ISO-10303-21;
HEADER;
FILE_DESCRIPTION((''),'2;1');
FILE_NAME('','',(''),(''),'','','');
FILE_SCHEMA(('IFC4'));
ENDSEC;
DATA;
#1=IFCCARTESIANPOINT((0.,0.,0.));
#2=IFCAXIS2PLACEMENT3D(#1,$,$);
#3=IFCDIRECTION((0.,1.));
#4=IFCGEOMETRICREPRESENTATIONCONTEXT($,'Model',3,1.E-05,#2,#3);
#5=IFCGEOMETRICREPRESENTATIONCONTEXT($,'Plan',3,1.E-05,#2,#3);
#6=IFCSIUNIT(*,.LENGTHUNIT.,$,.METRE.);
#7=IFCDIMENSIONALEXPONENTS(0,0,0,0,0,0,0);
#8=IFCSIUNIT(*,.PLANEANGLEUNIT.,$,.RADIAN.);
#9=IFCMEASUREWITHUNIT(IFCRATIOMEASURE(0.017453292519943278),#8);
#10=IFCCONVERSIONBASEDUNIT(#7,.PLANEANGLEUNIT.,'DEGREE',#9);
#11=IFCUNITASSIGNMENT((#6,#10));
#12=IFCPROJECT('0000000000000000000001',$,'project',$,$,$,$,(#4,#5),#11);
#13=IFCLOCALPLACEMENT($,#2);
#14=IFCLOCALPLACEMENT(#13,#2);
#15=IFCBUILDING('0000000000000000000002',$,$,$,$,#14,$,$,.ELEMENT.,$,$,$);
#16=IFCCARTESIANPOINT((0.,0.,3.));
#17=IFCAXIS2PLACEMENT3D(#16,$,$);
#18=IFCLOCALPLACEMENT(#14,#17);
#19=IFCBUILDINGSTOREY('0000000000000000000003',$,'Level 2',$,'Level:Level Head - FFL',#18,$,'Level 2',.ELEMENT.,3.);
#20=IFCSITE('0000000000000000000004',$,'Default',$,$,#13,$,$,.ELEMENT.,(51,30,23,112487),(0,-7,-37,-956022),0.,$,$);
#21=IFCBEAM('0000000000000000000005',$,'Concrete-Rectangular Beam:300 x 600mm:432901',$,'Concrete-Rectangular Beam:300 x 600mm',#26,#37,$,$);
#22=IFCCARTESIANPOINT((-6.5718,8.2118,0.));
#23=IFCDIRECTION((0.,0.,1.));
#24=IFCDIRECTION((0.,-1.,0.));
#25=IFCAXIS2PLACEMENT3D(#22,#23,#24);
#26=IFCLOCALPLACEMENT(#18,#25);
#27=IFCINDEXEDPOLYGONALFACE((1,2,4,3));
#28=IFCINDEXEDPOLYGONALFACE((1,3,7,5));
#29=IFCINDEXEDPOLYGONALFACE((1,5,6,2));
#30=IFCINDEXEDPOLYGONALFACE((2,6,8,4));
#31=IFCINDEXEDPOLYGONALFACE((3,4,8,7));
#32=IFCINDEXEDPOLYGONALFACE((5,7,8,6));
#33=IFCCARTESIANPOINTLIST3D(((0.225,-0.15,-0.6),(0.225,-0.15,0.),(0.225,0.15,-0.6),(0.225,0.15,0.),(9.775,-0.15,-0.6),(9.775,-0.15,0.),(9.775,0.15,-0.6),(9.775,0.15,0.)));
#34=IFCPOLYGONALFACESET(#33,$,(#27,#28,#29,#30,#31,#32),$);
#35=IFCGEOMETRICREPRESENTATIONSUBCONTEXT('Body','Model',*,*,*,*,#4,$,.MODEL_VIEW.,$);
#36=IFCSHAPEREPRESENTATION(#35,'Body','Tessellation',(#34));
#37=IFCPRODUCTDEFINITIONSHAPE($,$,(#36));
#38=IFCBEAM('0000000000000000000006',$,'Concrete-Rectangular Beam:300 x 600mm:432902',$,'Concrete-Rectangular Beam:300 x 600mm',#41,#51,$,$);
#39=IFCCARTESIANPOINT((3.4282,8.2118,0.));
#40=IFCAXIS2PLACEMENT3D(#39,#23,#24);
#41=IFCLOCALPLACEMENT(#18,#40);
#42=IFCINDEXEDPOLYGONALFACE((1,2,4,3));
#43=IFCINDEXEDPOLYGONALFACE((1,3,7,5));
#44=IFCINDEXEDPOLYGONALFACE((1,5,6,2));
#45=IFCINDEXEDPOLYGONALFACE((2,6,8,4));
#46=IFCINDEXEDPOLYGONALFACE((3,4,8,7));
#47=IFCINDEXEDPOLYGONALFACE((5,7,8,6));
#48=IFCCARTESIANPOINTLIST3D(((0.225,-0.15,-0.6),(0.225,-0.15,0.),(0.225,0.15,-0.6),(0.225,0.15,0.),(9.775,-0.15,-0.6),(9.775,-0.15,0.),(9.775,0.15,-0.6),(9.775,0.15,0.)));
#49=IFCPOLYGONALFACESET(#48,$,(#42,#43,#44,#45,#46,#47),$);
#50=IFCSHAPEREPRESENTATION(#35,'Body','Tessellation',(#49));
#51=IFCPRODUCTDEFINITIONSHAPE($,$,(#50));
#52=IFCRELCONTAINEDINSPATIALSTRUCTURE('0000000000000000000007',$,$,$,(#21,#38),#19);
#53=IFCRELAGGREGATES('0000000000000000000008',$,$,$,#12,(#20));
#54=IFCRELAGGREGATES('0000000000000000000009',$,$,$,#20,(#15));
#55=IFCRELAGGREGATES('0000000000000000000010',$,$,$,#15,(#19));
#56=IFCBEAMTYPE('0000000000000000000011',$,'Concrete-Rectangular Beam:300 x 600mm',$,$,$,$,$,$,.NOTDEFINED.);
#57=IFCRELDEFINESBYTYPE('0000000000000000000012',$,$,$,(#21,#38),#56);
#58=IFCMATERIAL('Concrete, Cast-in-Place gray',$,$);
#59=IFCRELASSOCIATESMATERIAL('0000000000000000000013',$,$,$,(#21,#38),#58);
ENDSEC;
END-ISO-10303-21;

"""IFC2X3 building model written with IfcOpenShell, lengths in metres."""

from ifc_helpers import new_model, entity, si_unit, converted_unit, direction, frame, frame_2d, origin, place, context, subcontext, project, spatial, rectangle, extrude, material, type_object, element, save


model = new_model("IFC2X3")

# Units and contexts
model_context = context("Model", 3, precision=1e-05, world=origin(), true_north=direction((0.0, 1.0)))
plan_context = context("Plan", 3, precision=1e-05, world=origin(), true_north=direction((0.0, 1.0)))
body_context = subcontext(model_context, "Body", "Model", "MODEL_VIEW")
ifc_project = project(units=[si_unit("LENGTHUNIT", "METRE"), converted_unit("PLANEANGLEUNIT", "DEGREE", entity("IfcRatioMeasure", 0.017453292519943278), si_unit("PLANEANGLEUNIT", "RADIAN"), dimensions=[0, 0, 0, 0, 0, 0, 0])], contexts=[model_context, plan_context])

# Site, building, storey
site_placement = place(None, origin())
site = spatial("IfcSite", under=ifc_project, at=site_placement, Name="Default", CompositionType="ELEMENT", RefLatitude=(51, 30, 23, 112487), RefLongitude=(0, -7, -37, -956022), RefElevation=0.0)
building_placement = place(site_placement, origin())
building = spatial("IfcBuilding", under=site, at=building_placement, CompositionType="ELEMENT")
storey_placement = place(building_placement, frame((0.0, 0.0, 3.0)))
storey = spatial("IfcBuildingStorey", under=building, at=storey_placement, Name="Level 2", ObjectType="Level:Level Head - FFL", LongName="Level 2", CompositionType="ELEMENT", Elevation=3.0)

# Beams
ifc_material_1 = material(Name="Concrete, Cast-in-Place gray")
beam_type = type_object("IfcBeamType", Name="Concrete-Rectangular Beam:300 x 600mm", PredefinedType="NOTDEFINED")
beam_1_placement = place(storey_placement, frame((-6.5718, 8.2118, 0.0), z_axis=(0.0, 0.0, 1.0), x_axis=(0.0, -1.0, 0.0)))
element("IfcBeam", 1, at=beam_1_placement, inside=storey, type_object=beam_type, material=ifc_material_1, Name="Concrete-Rectangular Beam:300 x 600mm:432901", ObjectType="Concrete-Rectangular Beam:300 x 600mm", context=body_context, shape_type="SweptSolid", body=[
    extrude(rectangle(XDim=0.6, YDim=0.3, at=frame_2d((0.0, 0.0), x_axis=(1.0, 0.0))), frame((0.225, 0.0, -0.3), z_axis=(1.0, 0.0, 0.0), x_axis=(0.0, 0.0, -1.0)), (0.0, 0.0, 1.0), 9.55),
])
beam_2_placement = place(storey_placement, frame((3.4282, 8.2118, 0.0), z_axis=(0.0, 0.0, 1.0), x_axis=(0.0, -1.0, 0.0)))
element("IfcBeam", 2, at=beam_2_placement, inside=storey, type_object=beam_type, material=ifc_material_1, Name="Concrete-Rectangular Beam:300 x 600mm:432902", ObjectType="Concrete-Rectangular Beam:300 x 600mm", context=body_context, shape_type="SweptSolid", body=[
    extrude(rectangle(XDim=0.6, YDim=0.3, at=frame_2d((0.0, 0.0), x_axis=(1.0, 0.0))), frame((0.225, 0.0, -0.3), z_axis=(1.0, 0.0, 0.0), x_axis=(0.0, 0.0, -1.0)), (0.0, 0.0, 1.0), 9.55),
])

save(model, "model.ifc")
